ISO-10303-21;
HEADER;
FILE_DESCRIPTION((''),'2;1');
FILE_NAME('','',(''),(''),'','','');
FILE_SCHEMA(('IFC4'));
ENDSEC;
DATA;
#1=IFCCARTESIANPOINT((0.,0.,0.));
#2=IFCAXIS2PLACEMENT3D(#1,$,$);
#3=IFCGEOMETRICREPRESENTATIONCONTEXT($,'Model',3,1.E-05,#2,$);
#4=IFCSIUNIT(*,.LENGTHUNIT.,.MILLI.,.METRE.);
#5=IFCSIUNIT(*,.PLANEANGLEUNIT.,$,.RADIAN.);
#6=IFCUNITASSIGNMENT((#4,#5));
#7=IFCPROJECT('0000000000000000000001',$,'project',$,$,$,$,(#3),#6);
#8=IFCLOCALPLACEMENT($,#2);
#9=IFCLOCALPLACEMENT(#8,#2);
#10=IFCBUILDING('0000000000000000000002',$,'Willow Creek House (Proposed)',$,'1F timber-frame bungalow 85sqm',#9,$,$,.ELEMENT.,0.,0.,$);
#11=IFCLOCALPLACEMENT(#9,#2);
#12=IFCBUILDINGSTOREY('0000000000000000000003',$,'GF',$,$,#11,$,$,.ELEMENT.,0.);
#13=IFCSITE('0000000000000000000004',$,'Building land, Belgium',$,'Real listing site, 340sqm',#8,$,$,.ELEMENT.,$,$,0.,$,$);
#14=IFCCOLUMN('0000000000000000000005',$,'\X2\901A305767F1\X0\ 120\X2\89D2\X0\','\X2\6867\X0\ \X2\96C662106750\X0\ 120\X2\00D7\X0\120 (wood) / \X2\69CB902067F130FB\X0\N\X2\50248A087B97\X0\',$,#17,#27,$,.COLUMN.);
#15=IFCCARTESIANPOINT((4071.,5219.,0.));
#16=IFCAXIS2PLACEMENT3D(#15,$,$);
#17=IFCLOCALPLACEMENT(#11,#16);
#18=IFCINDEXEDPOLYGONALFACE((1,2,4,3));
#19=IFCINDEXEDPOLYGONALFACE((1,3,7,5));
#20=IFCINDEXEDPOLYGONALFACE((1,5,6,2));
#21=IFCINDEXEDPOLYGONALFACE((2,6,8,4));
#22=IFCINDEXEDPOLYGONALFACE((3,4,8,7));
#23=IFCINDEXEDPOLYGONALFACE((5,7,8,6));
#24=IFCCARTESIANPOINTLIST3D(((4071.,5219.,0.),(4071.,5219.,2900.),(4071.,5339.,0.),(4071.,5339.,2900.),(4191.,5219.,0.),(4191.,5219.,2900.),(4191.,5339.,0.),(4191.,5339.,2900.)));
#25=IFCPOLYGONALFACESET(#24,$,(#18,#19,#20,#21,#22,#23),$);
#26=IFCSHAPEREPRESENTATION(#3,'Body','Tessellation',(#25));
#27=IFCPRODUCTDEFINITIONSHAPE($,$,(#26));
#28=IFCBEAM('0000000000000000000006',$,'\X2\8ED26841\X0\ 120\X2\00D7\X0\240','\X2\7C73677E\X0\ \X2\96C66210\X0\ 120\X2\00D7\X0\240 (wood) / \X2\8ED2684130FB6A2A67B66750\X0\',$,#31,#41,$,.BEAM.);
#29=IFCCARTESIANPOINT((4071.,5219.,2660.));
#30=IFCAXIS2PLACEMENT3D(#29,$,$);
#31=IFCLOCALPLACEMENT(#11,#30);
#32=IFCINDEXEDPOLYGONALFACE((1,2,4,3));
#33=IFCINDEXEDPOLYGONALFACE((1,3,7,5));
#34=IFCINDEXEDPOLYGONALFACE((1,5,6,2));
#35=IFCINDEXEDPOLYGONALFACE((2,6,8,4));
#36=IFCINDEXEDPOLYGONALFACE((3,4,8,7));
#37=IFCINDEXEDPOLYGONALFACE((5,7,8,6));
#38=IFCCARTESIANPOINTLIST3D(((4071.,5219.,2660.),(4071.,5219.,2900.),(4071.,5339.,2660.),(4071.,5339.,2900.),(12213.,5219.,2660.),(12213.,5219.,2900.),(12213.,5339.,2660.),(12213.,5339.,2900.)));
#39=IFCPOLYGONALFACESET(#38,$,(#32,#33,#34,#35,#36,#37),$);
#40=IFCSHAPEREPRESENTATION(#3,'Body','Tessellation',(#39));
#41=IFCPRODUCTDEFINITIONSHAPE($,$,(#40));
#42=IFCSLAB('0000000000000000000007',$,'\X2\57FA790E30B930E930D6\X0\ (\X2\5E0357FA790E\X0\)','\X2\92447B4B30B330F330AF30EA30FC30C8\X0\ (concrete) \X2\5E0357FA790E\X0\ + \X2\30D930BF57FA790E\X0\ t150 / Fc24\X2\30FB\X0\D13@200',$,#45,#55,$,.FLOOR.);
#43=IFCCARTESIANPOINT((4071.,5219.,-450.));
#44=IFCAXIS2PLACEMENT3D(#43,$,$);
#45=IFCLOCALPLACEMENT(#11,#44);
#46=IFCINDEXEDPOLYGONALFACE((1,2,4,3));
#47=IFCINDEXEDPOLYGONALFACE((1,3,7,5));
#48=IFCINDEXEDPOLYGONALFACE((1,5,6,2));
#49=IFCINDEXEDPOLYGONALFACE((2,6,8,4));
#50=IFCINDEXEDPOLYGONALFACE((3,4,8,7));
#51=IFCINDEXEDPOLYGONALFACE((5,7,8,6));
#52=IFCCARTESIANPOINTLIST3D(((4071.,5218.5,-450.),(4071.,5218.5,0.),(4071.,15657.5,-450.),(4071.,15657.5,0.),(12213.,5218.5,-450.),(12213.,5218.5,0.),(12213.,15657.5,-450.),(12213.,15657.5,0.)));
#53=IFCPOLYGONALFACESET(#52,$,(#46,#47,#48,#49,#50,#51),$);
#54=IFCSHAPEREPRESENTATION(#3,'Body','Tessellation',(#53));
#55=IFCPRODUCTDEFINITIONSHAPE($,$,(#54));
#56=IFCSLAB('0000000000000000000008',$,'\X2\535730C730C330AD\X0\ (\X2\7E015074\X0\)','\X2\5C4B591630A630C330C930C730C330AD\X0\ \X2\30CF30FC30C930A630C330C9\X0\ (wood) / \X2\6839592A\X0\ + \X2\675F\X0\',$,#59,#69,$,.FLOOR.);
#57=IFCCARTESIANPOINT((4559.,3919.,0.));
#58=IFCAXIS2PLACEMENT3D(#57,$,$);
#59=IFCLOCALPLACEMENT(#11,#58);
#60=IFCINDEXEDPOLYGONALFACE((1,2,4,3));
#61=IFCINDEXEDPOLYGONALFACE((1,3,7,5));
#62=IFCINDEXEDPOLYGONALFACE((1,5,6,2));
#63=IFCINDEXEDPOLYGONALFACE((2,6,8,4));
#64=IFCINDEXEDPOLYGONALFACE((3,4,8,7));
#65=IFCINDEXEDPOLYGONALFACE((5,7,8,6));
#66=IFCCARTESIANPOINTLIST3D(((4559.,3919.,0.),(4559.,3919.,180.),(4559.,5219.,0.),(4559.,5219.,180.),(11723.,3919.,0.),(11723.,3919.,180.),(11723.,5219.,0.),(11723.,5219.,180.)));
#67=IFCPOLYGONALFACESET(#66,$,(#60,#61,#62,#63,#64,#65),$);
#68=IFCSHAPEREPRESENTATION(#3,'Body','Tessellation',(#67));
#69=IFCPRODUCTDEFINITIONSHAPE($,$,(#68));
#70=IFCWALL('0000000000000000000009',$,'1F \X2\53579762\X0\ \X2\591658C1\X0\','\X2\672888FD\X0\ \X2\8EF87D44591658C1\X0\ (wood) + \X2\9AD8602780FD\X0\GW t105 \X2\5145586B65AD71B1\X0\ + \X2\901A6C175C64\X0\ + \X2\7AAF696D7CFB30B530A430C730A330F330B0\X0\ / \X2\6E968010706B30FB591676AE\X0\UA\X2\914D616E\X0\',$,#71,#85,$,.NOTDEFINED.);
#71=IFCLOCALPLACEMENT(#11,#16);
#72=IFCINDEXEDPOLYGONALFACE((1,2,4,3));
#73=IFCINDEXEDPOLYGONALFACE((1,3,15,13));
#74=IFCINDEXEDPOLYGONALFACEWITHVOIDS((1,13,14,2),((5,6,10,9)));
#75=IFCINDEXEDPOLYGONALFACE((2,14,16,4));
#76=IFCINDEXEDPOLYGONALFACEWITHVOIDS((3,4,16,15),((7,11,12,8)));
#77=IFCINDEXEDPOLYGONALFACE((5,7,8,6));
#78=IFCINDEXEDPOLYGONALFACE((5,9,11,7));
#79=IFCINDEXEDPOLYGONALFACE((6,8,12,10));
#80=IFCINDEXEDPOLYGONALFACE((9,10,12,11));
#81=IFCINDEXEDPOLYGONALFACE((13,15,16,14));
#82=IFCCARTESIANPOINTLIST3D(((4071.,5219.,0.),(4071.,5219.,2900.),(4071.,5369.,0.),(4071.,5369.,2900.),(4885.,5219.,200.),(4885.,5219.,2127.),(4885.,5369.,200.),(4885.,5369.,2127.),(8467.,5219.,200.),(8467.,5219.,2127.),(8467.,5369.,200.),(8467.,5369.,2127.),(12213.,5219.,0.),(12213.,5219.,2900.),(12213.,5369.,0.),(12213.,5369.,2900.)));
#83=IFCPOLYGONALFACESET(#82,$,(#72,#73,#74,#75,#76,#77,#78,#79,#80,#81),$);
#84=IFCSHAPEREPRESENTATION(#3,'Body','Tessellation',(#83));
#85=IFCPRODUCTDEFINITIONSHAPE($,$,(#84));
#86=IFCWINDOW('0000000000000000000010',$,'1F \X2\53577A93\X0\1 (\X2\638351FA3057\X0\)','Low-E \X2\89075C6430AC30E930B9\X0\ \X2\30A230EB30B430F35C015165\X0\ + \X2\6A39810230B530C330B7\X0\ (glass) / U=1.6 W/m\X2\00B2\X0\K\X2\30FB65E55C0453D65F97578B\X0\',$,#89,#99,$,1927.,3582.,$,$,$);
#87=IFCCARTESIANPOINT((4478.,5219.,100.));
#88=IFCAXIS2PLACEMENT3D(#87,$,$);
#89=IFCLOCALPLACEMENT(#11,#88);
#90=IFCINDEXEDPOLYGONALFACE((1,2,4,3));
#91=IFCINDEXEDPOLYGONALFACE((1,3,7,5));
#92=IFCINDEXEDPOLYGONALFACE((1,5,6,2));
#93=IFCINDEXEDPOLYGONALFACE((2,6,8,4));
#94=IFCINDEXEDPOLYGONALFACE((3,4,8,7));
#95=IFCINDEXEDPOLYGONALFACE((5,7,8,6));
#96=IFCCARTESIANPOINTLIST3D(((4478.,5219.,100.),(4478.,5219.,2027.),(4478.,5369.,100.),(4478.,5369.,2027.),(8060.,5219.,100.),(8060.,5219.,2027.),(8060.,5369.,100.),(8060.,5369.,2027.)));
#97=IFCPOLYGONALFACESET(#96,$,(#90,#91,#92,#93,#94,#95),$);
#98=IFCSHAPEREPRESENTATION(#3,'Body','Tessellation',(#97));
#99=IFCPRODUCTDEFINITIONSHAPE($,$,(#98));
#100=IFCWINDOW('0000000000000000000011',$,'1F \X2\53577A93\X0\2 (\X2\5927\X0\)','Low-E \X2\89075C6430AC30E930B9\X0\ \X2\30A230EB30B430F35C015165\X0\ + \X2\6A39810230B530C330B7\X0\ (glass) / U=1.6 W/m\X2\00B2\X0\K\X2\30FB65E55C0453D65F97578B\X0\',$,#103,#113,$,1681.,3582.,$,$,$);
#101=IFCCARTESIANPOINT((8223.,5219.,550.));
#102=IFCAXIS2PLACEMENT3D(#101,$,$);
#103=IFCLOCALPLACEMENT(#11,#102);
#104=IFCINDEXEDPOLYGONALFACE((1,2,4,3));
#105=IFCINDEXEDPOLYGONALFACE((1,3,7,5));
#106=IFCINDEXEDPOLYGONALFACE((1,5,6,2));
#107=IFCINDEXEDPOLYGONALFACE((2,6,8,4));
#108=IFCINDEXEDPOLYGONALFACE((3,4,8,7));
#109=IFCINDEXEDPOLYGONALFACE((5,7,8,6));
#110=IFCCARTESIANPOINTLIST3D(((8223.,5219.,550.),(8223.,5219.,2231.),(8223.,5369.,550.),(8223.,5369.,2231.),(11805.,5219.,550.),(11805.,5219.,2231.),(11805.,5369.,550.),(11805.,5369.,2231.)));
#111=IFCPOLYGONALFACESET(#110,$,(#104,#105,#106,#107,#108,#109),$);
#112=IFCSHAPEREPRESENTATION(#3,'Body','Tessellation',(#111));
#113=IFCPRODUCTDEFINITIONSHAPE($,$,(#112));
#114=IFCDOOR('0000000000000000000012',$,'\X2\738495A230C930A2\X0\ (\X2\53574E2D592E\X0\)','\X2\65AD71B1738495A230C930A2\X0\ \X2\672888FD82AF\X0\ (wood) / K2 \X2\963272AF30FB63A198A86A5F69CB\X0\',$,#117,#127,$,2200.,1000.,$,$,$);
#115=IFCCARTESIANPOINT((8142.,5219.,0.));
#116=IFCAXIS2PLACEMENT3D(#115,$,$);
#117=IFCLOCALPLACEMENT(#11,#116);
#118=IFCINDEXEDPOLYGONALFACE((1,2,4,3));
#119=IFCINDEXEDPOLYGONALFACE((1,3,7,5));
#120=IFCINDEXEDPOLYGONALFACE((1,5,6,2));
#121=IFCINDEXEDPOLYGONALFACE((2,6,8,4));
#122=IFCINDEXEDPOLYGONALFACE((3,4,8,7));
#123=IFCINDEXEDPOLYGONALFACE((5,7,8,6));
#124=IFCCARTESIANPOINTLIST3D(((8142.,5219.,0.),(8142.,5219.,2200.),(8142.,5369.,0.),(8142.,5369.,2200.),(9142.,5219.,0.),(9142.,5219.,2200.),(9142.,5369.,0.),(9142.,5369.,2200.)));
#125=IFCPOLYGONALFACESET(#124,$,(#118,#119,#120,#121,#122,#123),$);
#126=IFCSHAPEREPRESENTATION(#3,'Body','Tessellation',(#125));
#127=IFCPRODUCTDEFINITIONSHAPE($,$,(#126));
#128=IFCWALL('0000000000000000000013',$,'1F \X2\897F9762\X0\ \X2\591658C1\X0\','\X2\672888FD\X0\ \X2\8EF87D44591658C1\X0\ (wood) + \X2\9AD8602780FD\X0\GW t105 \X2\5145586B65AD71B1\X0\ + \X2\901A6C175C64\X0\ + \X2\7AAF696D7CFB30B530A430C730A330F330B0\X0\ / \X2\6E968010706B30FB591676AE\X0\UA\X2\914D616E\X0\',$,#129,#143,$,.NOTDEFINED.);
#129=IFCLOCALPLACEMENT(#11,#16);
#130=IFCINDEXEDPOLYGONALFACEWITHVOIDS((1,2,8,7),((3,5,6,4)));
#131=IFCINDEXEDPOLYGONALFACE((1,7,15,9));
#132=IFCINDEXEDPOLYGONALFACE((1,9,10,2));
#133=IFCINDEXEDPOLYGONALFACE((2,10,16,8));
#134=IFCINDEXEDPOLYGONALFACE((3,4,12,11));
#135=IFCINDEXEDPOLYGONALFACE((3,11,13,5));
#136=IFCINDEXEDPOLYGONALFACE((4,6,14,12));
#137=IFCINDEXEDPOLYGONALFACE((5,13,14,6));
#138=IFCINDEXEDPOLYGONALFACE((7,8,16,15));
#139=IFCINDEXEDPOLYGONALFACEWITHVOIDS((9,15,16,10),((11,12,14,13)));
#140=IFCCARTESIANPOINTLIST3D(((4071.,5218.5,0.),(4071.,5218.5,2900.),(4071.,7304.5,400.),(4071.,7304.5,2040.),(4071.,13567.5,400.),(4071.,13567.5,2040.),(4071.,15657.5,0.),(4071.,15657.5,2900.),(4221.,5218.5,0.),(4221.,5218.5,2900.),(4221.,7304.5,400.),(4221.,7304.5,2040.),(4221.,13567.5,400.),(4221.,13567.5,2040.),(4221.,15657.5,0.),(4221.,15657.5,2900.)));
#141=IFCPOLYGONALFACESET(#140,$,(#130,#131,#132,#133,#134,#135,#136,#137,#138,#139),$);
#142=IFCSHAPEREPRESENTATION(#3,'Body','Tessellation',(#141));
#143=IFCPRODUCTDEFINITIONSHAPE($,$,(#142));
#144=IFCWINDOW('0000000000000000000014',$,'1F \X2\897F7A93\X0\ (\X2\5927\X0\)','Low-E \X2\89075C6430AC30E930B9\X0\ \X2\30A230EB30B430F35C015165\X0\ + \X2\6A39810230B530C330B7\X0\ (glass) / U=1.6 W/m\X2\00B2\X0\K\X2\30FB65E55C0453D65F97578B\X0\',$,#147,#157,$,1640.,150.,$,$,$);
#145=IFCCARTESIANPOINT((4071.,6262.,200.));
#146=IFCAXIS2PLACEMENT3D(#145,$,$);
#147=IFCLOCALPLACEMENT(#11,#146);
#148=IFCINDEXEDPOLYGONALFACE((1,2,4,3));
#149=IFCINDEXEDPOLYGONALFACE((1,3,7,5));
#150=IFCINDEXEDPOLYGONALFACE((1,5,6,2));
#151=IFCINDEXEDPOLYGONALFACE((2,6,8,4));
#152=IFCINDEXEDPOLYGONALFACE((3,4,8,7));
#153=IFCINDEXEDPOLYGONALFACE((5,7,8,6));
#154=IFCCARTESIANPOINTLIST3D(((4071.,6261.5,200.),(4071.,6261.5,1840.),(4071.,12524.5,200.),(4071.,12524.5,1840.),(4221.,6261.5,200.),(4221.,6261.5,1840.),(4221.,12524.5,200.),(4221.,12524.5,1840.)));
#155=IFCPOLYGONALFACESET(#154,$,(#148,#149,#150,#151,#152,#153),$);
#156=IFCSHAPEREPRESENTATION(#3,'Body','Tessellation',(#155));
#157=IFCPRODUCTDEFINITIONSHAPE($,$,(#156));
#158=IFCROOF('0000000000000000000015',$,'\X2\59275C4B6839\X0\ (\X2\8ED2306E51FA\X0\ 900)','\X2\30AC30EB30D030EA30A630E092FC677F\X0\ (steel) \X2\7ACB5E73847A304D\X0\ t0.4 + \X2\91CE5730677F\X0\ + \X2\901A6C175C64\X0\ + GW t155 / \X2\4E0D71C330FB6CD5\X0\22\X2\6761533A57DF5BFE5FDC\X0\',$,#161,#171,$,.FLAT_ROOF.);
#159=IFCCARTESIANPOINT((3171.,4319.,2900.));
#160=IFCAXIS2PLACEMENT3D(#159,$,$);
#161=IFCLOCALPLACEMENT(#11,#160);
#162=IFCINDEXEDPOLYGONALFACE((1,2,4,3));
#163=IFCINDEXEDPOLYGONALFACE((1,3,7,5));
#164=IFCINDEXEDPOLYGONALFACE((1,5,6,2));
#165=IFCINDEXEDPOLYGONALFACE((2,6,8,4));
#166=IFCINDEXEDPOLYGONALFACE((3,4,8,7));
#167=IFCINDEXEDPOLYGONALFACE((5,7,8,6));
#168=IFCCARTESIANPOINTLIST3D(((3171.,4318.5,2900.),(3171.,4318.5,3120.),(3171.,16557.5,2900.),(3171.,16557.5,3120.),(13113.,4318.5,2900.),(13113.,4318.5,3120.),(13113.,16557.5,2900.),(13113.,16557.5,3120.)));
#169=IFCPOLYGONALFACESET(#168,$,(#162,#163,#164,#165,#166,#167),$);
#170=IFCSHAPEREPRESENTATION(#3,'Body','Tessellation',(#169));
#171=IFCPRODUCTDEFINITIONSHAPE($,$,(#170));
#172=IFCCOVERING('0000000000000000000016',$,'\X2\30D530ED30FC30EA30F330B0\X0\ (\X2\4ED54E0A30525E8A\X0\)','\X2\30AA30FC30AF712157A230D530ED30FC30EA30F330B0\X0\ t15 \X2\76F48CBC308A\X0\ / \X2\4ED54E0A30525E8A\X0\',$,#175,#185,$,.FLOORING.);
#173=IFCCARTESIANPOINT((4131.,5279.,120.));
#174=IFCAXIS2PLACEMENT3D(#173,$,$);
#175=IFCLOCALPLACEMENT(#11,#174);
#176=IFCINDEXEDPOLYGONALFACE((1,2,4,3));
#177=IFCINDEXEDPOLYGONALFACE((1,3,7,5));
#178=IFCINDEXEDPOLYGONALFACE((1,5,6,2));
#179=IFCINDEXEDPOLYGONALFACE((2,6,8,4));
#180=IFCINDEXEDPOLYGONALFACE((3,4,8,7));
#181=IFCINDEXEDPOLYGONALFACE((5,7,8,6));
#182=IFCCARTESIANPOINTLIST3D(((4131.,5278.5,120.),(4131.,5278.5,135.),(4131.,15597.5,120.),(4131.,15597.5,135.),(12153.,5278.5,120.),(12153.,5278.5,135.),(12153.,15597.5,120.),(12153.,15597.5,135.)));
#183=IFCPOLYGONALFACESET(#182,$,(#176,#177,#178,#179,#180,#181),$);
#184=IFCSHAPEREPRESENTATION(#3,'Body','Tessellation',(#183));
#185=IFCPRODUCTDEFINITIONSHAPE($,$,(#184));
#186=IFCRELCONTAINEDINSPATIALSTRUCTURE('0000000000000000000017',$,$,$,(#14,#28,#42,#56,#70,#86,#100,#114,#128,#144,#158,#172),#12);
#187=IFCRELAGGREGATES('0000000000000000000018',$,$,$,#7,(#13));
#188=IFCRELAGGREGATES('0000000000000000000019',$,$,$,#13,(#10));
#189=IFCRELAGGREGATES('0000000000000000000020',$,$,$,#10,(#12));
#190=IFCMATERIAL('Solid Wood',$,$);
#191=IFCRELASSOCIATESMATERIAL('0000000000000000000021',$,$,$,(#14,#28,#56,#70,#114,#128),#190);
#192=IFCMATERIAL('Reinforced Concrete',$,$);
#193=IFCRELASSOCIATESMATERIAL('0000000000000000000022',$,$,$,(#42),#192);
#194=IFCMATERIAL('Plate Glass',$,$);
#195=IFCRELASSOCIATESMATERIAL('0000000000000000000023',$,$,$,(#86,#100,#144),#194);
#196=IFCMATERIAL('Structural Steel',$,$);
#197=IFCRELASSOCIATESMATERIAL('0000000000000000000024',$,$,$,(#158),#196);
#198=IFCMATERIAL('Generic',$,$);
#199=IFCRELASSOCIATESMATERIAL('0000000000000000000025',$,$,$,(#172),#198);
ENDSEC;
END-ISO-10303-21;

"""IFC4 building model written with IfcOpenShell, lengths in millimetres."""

from ifc_helpers import new_model, si_unit, frame, frame_2d, origin, place, context, project, spatial, rectangle, extrude, material, element, fill, save


model = new_model("IFC4")

# Units and contexts
model_context = context("Model", 3, precision=1e-05, world=origin())
ifc_project = project(units=[si_unit("LENGTHUNIT", "METRE", prefix="MILLI"), si_unit("PLANEANGLEUNIT", "RADIAN")], contexts=[model_context])

# Site, building, storey
site_placement = place(None, origin())
site = spatial("IfcSite", under=ifc_project, at=site_placement, Name="Building land, Belgium", ObjectType="Real listing site, 340sqm", CompositionType="ELEMENT", RefElevation=0.0)
building_placement = place(site_placement, origin())
building = spatial("IfcBuilding", under=site, at=building_placement, Name="Willow Creek House (Proposed)", ObjectType="1F timber-frame bungalow 85sqm", CompositionType="ELEMENT", ElevationOfRefHeight=0.0, ElevationOfTerrain=0.0)
storey_placement = place(building_placement, origin())
storey = spatial("IfcBuildingStorey", under=building, at=storey_placement, Name="GF", CompositionType="ELEMENT", Elevation=0.0)

# Column
ifc_material_1 = material(Name="Solid Wood")
column_1_placement = place(storey_placement, frame((4071.0, 5219.0, 0.0)))
element("IfcColumn", 1, at=column_1_placement, inside=storey, material=ifc_material_1, Name="通し柱 120角", Description="桧 集成材 120×120 (wood) / 構造柱・N値計算", PredefinedType="COLUMN", context=model_context, shape_type="SweptSolid", body=[
    extrude(rectangle(XDim=120.0, YDim=120.0, at=frame_2d((60.0, 60.0))), frame((4071.0, 5219.0, 0.0)), (0.0, 0.0, 1.0), 2900.0),
])

# Beam
beam_1_placement = place(storey_placement, frame((4071.0, 5219.0, 2660.0)))
element("IfcBeam", 2, at=beam_1_placement, inside=storey, material=ifc_material_1, Name="軒桁 120×240", Description="米松 集成 120×240 (wood) / 軒桁・横架材", PredefinedType="BEAM", context=model_context, shape_type="SweptSolid", body=[
    extrude(rectangle(XDim=8142.0, YDim=120.0, at=frame_2d((4071.0, 60.0))), frame((4071.0, 5219.0, 2660.0)), (0.0, 0.0, 1.0), 240.0),
])

# Slabs
ifc_material_2 = material(Name="Reinforced Concrete")
slab_1_placement = place(storey_placement, frame((4071.0, 5219.0, -450.0)))
element("IfcSlab", 3, at=slab_1_placement, inside=storey, material=ifc_material_2, Name="基礎スラブ (布基礎)", Description="鉄筋コンクリート (concrete) 布基礎 + ベタ基礎 t150 / Fc24・D13@200", PredefinedType="FLOOR", context=model_context, shape_type="SweptSolid", body=[
    extrude(rectangle(XDim=8142.0, YDim=10439.0, at=frame_2d((4071.0, 5219.0))), frame((4071.0, 5219.0, -450.0)), (0.0, 0.0, 1.0), 450.0),
])
slab_2_placement = place(storey_placement, frame((4559.0, 3919.0, 0.0)))
element("IfcSlab", 4, at=slab_2_placement, inside=storey, material=ifc_material_1, Name="南デッキ (縁側)", Description="屋外ウッドデッキ ハードウッド (wood) / 根太 + 束", PredefinedType="FLOOR", context=model_context, shape_type="SweptSolid", body=[
    extrude(rectangle(XDim=7164.0, YDim=1300.0, at=frame_2d((3582.0, 650.0))), frame((4559.0, 3919.0, 0.0)), (0.0, 0.0, 1.0), 180.0),
])

# Wall, openings, windows, door
wall_1_placement = place(storey_placement, frame((4071.0, 5219.0, 0.0)))
wall_1 = element("IfcWall", 5, at=wall_1_placement, inside=storey, material=ifc_material_1, Name="1F 南面 外壁", Description="木製 軸組外壁 (wood) + 高性能GW t105 充填断熱 + 通気層 + 窯業系サイディング / 準耐火・外皮UA配慮", PredefinedType="NOTDEFINED", context=model_context, shape_type="SweptSolid", body=[
    extrude(rectangle(XDim=8142.0, YDim=150.0, at=frame_2d((4071.0, 75.0))), frame((4071.0, 5219.0, 0.0)), (0.0, 0.0, 1.0), 2900.0),
])
opening_1_placement = place(storey_placement, frame((4478.0, 5219.0, 100.0)))
opening_1 = element("IfcOpeningElement", 6, at=opening_1_placement, cuts=wall_1, PredefinedType="NOTDEFINED", context=model_context, shape_type="SweptSolid", body=[
    extrude(rectangle(XDim=3582.0, YDim=150.0, at=frame_2d((1791.0, 75.0))), frame((4478.0, 5219.0, 100.0)), (0.0, 0.0, 1.0), 1927.0),
])
opening_2_placement = place(storey_placement, frame((8223.0, 5219.0, 550.0)))
opening_2 = element("IfcOpeningElement", 7, at=opening_2_placement, cuts=wall_1, PredefinedType="NOTDEFINED", context=model_context, shape_type="SweptSolid", body=[
    extrude(rectangle(XDim=3582.0, YDim=150.0, at=frame_2d((1791.0, 75.0))), frame((8223.0, 5219.0, 550.0)), (0.0, 0.0, 1.0), 1681.0),
])
opening_3_placement = place(storey_placement, frame((8142.0, 5219.0, 0.0)))
opening_3 = element("IfcOpeningElement", 8, at=opening_3_placement, cuts=wall_1, PredefinedType="NOTDEFINED", context=model_context, shape_type="SweptSolid", body=[
    extrude(rectangle(XDim=1000.0, YDim=150.0, at=frame_2d((500.0, 75.0))), frame((8142.0, 5219.0, 0.0)), (0.0, 0.0, 1.0), 2200.0),
])
ifc_material_3 = material(Name="Plate Glass")
window_1_placement = place(storey_placement, frame((4478.0, 5219.0, 100.0)))
window_1 = element("IfcWindow", 9, at=window_1_placement, inside=storey, material=ifc_material_3, Name="1F 南窓1 (掃出し)", Description="Low-E 複層ガラス アルゴン封入 + 樹脂サッシ (glass) / U=1.6 W/m²K・日射取得型", OverallHeight=1927.0, OverallWidth=3582.0, context=model_context, shape_type="SweptSolid", body=[
    extrude(rectangle(XDim=3582.0, YDim=150.0, at=frame_2d((1791.0, 75.0))), frame((4478.0, 5219.0, 100.0)), (0.0, 0.0, 1.0), 1927.0),
])
fill(opening_1, window_1)
window_2_placement = place(storey_placement, frame((8223.0, 5219.0, 550.0)))
window_2 = element("IfcWindow", 10, at=window_2_placement, inside=storey, material=ifc_material_3, Name="1F 南窓2 (大)", Description="Low-E 複層ガラス アルゴン封入 + 樹脂サッシ (glass) / U=1.6 W/m²K・日射取得型", OverallHeight=1681.0, OverallWidth=3582.0, context=model_context, shape_type="SweptSolid", body=[
    extrude(rectangle(XDim=3582.0, YDim=150.0, at=frame_2d((1791.0, 75.0))), frame((8223.0, 5219.0, 550.0)), (0.0, 0.0, 1.0), 1681.0),
])
fill(opening_2, window_2)
door_placement = place(storey_placement, frame((8142.0, 5219.0, 0.0)))
door = element("IfcDoor", 11, at=door_placement, inside=storey, material=ifc_material_1, Name="玄関ドア (南中央)", Description="断熱玄関ドア 木製芯 (wood) / K2 防犯・採風機構", OverallHeight=2200.0, OverallWidth=1000.0, context=model_context, shape_type="SweptSolid", body=[
    extrude(rectangle(XDim=1000.0, YDim=150.0, at=frame_2d((500.0, 75.0))), frame((8142.0, 5219.0, 0.0)), (0.0, 0.0, 1.0), 2200.0),
])
fill(opening_3, door)

# Wall, opening, window
wall_2_placement = place(storey_placement, frame((4071.0, 5219.0, 0.0)))
wall_2 = element("IfcWall", 12, at=wall_2_placement, inside=storey, material=ifc_material_1, Name="1F 西面 外壁", Description="木製 軸組外壁 (wood) + 高性能GW t105 充填断熱 + 通気層 + 窯業系サイディング / 準耐火・外皮UA配慮", PredefinedType="NOTDEFINED", context=model_context, shape_type="SweptSolid", body=[
    extrude(rectangle(XDim=150.0, YDim=10439.0, at=frame_2d((75.0, 5219.0))), frame((4071.0, 5219.0, 0.0)), (0.0, 0.0, 1.0), 2900.0),
])
opening_4_placement = place(storey_placement, frame((4071.0, 6262.0, 200.0)))
opening_4 = element("IfcOpeningElement", 13, at=opening_4_placement, cuts=wall_2, PredefinedType="NOTDEFINED", context=model_context, shape_type="SweptSolid", body=[
    extrude(rectangle(XDim=150.0, YDim=6263.0, at=frame_2d((75.0, 3131.0))), frame((4071.0, 6262.0, 200.0)), (0.0, 0.0, 1.0), 1640.0),
])
window_3_placement = place(storey_placement, frame((4071.0, 6262.0, 200.0)))
window_3 = element("IfcWindow", 14, at=window_3_placement, inside=storey, material=ifc_material_3, Name="1F 西窓 (大)", Description="Low-E 複層ガラス アルゴン封入 + 樹脂サッシ (glass) / U=1.6 W/m²K・日射取得型", OverallHeight=1640.0, OverallWidth=150.0, context=model_context, shape_type="SweptSolid", body=[
    extrude(rectangle(XDim=150.0, YDim=6263.0, at=frame_2d((75.0, 3131.0))), frame((4071.0, 6262.0, 200.0)), (0.0, 0.0, 1.0), 1640.0),
])
fill(opening_4, window_3)

# Roof
ifc_material_4 = material(Name="Structural Steel")
roof_placement = place(storey_placement, frame((3171.0, 4319.0, 2900.0)))
element("IfcRoof", 15, at=roof_placement, inside=storey, material=ifc_material_4, Name="大屋根 (軒の出 900)", Description="ガルバリウム鋼板 (steel) 立平葺き t0.4 + 野地板 + 通気層 + GW t155 / 不燃・法22条区域対応", PredefinedType="FLAT_ROOF", context=model_context, shape_type="SweptSolid", body=[
    extrude(rectangle(XDim=9942.0, YDim=12239.0, at=frame_2d((4971.0, 6119.0))), frame((3171.0, 4319.0, 2900.0)), (0.0, 0.0, 1.0), 220.0),
])

# Covering
ifc_material_5 = material(Name="Generic")
covering_1_placement = place(storey_placement, frame((4131.0, 5279.0, 120.0)))
element("IfcCovering", 16, at=covering_1_placement, inside=storey, material=ifc_material_5, Name="フローリング (仕上げ床)", Description="オーク無垢フローリング t15 直貼り / 仕上げ床", PredefinedType="FLOORING", context=model_context, shape_type="SweptSolid", body=[
    extrude(rectangle(XDim=8022.0, YDim=10319.0, at=frame_2d((4011.0, 5159.0))), frame((4131.0, 5279.0, 120.0)), (0.0, 0.0, 1.0), 15.0),
])

save(model, "model.ifc")
